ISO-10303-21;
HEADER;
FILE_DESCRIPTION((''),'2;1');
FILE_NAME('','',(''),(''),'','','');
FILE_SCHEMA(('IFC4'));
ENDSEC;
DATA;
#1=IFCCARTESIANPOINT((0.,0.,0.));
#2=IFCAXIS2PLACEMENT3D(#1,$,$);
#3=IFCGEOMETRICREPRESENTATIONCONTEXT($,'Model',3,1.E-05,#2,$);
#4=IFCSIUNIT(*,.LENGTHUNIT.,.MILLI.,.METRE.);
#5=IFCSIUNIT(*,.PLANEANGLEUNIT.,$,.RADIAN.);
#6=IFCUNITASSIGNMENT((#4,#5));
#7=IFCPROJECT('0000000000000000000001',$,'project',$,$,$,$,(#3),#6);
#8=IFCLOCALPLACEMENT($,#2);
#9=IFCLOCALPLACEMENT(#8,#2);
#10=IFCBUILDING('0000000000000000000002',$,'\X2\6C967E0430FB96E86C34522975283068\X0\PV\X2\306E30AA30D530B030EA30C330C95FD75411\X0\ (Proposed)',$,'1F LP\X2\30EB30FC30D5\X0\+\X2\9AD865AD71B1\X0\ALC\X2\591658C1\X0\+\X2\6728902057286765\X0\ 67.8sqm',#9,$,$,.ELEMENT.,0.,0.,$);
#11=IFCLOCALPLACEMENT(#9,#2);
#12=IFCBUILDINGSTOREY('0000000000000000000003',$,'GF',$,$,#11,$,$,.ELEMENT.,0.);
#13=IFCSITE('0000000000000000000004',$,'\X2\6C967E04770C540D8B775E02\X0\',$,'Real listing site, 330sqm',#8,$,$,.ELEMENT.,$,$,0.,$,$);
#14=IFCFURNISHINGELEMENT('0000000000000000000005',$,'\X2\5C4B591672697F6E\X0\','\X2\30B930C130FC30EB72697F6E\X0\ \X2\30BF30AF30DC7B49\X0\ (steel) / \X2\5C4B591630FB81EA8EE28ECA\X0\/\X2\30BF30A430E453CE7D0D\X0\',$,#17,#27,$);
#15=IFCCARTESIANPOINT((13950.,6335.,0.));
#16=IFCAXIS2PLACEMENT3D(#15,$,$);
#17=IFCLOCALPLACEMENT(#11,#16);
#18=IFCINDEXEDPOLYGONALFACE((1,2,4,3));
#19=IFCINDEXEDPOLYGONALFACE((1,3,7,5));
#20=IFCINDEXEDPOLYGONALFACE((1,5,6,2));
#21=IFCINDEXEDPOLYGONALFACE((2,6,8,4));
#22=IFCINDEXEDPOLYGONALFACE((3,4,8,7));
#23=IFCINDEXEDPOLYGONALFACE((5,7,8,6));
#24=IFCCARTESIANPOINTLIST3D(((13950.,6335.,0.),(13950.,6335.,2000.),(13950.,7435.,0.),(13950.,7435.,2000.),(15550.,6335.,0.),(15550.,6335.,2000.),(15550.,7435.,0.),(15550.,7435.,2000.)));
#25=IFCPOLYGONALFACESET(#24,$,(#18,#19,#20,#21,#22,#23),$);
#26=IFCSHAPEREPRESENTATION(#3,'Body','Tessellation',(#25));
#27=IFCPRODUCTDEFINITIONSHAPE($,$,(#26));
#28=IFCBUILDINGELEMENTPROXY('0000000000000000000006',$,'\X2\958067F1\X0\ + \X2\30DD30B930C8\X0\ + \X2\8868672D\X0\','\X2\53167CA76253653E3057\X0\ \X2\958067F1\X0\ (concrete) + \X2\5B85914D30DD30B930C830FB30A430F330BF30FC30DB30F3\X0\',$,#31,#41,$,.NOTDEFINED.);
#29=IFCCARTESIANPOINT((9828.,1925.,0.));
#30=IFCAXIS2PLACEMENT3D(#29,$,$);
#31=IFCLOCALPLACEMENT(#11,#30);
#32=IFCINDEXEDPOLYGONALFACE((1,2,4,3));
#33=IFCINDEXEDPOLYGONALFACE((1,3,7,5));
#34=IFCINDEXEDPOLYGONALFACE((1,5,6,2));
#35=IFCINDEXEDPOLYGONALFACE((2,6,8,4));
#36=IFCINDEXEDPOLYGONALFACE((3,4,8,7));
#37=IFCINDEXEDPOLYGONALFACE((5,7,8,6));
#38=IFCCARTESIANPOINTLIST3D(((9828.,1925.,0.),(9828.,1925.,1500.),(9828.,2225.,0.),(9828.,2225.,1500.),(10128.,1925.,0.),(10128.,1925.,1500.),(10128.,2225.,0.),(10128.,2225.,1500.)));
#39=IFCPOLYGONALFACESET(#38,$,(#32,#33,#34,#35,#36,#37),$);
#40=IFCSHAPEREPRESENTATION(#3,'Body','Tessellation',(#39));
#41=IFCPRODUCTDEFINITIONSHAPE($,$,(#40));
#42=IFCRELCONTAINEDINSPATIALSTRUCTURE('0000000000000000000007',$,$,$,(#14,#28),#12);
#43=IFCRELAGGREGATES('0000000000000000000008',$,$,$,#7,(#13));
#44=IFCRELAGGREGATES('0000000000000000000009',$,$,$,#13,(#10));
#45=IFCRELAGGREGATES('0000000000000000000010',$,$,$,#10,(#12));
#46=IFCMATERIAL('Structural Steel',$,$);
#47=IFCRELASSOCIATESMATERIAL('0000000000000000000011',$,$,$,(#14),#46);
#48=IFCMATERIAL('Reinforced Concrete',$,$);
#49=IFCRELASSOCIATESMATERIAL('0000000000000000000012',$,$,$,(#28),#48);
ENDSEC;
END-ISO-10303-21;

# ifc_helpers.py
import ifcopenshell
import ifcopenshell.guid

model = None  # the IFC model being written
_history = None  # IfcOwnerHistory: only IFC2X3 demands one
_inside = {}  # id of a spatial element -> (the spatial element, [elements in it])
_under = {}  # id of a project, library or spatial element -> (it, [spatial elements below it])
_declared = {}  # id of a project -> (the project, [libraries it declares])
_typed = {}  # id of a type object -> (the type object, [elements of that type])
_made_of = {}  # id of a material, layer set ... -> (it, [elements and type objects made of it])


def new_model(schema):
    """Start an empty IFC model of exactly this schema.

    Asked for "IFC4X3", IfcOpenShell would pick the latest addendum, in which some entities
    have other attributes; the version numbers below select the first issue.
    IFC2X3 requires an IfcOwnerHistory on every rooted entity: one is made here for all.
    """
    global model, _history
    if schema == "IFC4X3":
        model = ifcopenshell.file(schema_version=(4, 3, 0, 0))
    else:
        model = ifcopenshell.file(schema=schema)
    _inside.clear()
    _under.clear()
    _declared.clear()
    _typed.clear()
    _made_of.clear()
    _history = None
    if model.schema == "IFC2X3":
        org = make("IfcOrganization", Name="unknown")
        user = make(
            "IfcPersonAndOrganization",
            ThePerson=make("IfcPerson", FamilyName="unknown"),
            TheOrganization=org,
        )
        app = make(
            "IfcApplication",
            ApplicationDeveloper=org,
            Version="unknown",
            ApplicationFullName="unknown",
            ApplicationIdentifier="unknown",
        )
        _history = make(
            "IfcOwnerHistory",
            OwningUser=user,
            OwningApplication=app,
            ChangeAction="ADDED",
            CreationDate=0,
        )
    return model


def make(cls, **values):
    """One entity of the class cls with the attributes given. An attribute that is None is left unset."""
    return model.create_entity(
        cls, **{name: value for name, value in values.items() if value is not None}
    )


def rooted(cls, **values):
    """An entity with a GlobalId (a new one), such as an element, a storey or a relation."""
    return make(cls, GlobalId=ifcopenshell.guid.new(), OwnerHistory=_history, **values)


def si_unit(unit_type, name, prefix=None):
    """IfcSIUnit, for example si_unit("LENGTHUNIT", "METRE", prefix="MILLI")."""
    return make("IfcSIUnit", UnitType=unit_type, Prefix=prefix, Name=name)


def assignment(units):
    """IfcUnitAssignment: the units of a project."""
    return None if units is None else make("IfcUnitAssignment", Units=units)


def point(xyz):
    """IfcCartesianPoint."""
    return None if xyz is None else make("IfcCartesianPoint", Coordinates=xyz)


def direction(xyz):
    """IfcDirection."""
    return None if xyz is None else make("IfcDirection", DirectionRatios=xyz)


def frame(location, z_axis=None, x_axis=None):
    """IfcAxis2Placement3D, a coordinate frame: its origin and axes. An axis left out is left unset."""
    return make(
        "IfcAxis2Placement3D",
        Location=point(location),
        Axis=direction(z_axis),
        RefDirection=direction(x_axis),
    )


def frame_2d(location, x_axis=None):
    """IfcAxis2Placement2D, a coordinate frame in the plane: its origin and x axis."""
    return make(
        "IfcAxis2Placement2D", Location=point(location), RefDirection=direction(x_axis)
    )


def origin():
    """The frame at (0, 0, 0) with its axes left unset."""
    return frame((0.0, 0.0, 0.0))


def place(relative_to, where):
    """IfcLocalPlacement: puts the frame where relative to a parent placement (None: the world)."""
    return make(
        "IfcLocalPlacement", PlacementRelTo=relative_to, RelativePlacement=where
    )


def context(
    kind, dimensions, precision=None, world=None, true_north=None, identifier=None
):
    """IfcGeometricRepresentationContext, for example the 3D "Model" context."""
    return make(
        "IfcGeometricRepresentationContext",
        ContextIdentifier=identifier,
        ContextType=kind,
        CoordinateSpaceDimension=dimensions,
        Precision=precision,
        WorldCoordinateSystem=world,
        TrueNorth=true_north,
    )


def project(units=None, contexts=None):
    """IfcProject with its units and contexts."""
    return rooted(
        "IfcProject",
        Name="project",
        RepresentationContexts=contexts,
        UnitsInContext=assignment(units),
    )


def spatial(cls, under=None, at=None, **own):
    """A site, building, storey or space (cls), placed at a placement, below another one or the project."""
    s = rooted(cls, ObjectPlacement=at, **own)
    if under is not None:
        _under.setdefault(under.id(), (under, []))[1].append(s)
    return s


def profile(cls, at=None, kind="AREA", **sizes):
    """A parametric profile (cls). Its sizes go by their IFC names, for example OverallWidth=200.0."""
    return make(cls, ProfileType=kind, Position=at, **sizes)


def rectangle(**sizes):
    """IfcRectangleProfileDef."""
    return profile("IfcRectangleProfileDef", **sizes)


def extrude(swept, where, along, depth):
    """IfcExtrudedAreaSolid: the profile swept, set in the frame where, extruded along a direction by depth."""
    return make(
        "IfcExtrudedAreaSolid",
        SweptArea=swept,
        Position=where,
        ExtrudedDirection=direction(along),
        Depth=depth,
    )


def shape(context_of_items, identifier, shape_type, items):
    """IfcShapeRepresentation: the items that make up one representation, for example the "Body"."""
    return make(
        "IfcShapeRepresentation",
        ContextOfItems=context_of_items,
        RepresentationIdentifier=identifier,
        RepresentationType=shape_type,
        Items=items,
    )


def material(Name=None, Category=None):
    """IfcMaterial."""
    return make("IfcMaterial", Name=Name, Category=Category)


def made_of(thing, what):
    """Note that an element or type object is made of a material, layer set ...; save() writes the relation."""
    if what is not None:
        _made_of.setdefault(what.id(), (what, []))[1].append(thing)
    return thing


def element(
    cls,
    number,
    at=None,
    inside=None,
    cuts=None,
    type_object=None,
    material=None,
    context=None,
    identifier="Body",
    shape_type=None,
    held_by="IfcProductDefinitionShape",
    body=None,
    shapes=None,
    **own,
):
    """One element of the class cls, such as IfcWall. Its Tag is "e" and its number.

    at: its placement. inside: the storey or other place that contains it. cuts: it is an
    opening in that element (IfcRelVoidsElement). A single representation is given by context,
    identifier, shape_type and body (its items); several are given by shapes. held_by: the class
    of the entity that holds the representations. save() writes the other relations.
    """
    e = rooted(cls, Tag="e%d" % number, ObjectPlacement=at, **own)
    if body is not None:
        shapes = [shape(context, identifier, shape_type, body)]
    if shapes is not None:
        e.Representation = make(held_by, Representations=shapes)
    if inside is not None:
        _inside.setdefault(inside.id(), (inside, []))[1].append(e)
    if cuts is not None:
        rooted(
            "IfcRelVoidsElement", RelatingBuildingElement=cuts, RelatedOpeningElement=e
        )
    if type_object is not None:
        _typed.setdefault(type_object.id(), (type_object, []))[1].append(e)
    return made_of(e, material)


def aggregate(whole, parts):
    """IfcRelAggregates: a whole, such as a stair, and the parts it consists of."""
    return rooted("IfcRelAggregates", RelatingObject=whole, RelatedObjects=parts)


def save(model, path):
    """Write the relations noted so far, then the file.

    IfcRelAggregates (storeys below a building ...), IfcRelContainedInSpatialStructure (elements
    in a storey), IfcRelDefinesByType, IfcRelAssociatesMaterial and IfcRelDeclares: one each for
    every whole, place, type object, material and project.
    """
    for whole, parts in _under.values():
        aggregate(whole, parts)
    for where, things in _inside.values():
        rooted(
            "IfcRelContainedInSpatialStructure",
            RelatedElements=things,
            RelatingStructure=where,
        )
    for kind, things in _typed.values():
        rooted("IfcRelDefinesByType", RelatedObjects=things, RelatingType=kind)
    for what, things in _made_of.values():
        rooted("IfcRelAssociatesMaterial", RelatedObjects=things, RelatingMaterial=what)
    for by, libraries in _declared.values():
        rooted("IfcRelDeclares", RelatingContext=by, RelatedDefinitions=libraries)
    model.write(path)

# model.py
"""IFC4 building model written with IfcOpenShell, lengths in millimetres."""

from ifc_helpers import new_model, si_unit, frame, frame_2d, origin, place, context, project, spatial, rectangle, extrude, material, element, save


model = new_model("IFC4")

# Units and contexts
model_context = context("Model", 3, precision=1e-05, world=origin())
ifc_project = project(units=[si_unit("LENGTHUNIT", "METRE", prefix="MILLI"), si_unit("PLANEANGLEUNIT", "RADIAN")], contexts=[model_context])

# Site, building, storey
site_placement = place(None, origin())
site = spatial("IfcSite", under=ifc_project, at=site_placement, Name="沖縄県名護市", ObjectType="Real listing site, 330sqm", CompositionType="ELEMENT", RefElevation=0.0)
building_placement = place(site_placement, origin())
building = spatial("IfcBuilding", under=site, at=building_placement, Name="沖縄・雨水利用とPVのオフグリッド志向 (Proposed)", ObjectType="1F LPルーフ+高断熱ALC外壁+木造在来 67.8sqm", CompositionType="ELEMENT", ElevationOfRefHeight=0.0, ElevationOfTerrain=0.0)
storey_placement = place(building_placement, origin())
storey = spatial("IfcBuildingStorey", under=building, at=storey_placement, Name="GF", CompositionType="ELEMENT", Elevation=0.0)

# Shared definitions
ifc_material_1 = material(Name="Reinforced Concrete")

# Shared definitions
ifc_material_2 = material(Name="Structural Steel")

# Furnishing element
furnishing_1_placement = place(storey_placement, frame((13950.0, 6335.0, 0.0)))
element("IfcFurnishingElement", 1, at=furnishing_1_placement, inside=storey, material=ifc_material_2, Name="屋外物置", Description="スチール物置 タクボ等 (steel) / 屋外・自転車/タイヤ収納", context=model_context, shape_type="SweptSolid", body=[
    extrude(rectangle(XDim=1600.0, YDim=1100.0, at=frame_2d((800.0, 550.0))), frame((13950.0, 6335.0, 0.0)), (0.0, 0.0, 1.0), 2000.0),
])

# Building element proxy
proxy_placement = place(storey_placement, frame((9828.0, 1925.0, 0.0)))
element("IfcBuildingElementProxy", 2, at=proxy_placement, inside=storey, material=ifc_material_1, Name="門柱 + ポスト + 表札", Description="化粧打放し 門柱 (concrete) + 宅配ポスト・インターホン", PredefinedType="NOTDEFINED", context=model_context, shape_type="SweptSolid", body=[
    extrude(rectangle(XDim=300.0, YDim=300.0, at=frame_2d((150.0, 150.0))), frame((9828.0, 1925.0, 0.0)), (0.0, 0.0, 1.0), 1500.0),
])

save(model, "model.ifc")
